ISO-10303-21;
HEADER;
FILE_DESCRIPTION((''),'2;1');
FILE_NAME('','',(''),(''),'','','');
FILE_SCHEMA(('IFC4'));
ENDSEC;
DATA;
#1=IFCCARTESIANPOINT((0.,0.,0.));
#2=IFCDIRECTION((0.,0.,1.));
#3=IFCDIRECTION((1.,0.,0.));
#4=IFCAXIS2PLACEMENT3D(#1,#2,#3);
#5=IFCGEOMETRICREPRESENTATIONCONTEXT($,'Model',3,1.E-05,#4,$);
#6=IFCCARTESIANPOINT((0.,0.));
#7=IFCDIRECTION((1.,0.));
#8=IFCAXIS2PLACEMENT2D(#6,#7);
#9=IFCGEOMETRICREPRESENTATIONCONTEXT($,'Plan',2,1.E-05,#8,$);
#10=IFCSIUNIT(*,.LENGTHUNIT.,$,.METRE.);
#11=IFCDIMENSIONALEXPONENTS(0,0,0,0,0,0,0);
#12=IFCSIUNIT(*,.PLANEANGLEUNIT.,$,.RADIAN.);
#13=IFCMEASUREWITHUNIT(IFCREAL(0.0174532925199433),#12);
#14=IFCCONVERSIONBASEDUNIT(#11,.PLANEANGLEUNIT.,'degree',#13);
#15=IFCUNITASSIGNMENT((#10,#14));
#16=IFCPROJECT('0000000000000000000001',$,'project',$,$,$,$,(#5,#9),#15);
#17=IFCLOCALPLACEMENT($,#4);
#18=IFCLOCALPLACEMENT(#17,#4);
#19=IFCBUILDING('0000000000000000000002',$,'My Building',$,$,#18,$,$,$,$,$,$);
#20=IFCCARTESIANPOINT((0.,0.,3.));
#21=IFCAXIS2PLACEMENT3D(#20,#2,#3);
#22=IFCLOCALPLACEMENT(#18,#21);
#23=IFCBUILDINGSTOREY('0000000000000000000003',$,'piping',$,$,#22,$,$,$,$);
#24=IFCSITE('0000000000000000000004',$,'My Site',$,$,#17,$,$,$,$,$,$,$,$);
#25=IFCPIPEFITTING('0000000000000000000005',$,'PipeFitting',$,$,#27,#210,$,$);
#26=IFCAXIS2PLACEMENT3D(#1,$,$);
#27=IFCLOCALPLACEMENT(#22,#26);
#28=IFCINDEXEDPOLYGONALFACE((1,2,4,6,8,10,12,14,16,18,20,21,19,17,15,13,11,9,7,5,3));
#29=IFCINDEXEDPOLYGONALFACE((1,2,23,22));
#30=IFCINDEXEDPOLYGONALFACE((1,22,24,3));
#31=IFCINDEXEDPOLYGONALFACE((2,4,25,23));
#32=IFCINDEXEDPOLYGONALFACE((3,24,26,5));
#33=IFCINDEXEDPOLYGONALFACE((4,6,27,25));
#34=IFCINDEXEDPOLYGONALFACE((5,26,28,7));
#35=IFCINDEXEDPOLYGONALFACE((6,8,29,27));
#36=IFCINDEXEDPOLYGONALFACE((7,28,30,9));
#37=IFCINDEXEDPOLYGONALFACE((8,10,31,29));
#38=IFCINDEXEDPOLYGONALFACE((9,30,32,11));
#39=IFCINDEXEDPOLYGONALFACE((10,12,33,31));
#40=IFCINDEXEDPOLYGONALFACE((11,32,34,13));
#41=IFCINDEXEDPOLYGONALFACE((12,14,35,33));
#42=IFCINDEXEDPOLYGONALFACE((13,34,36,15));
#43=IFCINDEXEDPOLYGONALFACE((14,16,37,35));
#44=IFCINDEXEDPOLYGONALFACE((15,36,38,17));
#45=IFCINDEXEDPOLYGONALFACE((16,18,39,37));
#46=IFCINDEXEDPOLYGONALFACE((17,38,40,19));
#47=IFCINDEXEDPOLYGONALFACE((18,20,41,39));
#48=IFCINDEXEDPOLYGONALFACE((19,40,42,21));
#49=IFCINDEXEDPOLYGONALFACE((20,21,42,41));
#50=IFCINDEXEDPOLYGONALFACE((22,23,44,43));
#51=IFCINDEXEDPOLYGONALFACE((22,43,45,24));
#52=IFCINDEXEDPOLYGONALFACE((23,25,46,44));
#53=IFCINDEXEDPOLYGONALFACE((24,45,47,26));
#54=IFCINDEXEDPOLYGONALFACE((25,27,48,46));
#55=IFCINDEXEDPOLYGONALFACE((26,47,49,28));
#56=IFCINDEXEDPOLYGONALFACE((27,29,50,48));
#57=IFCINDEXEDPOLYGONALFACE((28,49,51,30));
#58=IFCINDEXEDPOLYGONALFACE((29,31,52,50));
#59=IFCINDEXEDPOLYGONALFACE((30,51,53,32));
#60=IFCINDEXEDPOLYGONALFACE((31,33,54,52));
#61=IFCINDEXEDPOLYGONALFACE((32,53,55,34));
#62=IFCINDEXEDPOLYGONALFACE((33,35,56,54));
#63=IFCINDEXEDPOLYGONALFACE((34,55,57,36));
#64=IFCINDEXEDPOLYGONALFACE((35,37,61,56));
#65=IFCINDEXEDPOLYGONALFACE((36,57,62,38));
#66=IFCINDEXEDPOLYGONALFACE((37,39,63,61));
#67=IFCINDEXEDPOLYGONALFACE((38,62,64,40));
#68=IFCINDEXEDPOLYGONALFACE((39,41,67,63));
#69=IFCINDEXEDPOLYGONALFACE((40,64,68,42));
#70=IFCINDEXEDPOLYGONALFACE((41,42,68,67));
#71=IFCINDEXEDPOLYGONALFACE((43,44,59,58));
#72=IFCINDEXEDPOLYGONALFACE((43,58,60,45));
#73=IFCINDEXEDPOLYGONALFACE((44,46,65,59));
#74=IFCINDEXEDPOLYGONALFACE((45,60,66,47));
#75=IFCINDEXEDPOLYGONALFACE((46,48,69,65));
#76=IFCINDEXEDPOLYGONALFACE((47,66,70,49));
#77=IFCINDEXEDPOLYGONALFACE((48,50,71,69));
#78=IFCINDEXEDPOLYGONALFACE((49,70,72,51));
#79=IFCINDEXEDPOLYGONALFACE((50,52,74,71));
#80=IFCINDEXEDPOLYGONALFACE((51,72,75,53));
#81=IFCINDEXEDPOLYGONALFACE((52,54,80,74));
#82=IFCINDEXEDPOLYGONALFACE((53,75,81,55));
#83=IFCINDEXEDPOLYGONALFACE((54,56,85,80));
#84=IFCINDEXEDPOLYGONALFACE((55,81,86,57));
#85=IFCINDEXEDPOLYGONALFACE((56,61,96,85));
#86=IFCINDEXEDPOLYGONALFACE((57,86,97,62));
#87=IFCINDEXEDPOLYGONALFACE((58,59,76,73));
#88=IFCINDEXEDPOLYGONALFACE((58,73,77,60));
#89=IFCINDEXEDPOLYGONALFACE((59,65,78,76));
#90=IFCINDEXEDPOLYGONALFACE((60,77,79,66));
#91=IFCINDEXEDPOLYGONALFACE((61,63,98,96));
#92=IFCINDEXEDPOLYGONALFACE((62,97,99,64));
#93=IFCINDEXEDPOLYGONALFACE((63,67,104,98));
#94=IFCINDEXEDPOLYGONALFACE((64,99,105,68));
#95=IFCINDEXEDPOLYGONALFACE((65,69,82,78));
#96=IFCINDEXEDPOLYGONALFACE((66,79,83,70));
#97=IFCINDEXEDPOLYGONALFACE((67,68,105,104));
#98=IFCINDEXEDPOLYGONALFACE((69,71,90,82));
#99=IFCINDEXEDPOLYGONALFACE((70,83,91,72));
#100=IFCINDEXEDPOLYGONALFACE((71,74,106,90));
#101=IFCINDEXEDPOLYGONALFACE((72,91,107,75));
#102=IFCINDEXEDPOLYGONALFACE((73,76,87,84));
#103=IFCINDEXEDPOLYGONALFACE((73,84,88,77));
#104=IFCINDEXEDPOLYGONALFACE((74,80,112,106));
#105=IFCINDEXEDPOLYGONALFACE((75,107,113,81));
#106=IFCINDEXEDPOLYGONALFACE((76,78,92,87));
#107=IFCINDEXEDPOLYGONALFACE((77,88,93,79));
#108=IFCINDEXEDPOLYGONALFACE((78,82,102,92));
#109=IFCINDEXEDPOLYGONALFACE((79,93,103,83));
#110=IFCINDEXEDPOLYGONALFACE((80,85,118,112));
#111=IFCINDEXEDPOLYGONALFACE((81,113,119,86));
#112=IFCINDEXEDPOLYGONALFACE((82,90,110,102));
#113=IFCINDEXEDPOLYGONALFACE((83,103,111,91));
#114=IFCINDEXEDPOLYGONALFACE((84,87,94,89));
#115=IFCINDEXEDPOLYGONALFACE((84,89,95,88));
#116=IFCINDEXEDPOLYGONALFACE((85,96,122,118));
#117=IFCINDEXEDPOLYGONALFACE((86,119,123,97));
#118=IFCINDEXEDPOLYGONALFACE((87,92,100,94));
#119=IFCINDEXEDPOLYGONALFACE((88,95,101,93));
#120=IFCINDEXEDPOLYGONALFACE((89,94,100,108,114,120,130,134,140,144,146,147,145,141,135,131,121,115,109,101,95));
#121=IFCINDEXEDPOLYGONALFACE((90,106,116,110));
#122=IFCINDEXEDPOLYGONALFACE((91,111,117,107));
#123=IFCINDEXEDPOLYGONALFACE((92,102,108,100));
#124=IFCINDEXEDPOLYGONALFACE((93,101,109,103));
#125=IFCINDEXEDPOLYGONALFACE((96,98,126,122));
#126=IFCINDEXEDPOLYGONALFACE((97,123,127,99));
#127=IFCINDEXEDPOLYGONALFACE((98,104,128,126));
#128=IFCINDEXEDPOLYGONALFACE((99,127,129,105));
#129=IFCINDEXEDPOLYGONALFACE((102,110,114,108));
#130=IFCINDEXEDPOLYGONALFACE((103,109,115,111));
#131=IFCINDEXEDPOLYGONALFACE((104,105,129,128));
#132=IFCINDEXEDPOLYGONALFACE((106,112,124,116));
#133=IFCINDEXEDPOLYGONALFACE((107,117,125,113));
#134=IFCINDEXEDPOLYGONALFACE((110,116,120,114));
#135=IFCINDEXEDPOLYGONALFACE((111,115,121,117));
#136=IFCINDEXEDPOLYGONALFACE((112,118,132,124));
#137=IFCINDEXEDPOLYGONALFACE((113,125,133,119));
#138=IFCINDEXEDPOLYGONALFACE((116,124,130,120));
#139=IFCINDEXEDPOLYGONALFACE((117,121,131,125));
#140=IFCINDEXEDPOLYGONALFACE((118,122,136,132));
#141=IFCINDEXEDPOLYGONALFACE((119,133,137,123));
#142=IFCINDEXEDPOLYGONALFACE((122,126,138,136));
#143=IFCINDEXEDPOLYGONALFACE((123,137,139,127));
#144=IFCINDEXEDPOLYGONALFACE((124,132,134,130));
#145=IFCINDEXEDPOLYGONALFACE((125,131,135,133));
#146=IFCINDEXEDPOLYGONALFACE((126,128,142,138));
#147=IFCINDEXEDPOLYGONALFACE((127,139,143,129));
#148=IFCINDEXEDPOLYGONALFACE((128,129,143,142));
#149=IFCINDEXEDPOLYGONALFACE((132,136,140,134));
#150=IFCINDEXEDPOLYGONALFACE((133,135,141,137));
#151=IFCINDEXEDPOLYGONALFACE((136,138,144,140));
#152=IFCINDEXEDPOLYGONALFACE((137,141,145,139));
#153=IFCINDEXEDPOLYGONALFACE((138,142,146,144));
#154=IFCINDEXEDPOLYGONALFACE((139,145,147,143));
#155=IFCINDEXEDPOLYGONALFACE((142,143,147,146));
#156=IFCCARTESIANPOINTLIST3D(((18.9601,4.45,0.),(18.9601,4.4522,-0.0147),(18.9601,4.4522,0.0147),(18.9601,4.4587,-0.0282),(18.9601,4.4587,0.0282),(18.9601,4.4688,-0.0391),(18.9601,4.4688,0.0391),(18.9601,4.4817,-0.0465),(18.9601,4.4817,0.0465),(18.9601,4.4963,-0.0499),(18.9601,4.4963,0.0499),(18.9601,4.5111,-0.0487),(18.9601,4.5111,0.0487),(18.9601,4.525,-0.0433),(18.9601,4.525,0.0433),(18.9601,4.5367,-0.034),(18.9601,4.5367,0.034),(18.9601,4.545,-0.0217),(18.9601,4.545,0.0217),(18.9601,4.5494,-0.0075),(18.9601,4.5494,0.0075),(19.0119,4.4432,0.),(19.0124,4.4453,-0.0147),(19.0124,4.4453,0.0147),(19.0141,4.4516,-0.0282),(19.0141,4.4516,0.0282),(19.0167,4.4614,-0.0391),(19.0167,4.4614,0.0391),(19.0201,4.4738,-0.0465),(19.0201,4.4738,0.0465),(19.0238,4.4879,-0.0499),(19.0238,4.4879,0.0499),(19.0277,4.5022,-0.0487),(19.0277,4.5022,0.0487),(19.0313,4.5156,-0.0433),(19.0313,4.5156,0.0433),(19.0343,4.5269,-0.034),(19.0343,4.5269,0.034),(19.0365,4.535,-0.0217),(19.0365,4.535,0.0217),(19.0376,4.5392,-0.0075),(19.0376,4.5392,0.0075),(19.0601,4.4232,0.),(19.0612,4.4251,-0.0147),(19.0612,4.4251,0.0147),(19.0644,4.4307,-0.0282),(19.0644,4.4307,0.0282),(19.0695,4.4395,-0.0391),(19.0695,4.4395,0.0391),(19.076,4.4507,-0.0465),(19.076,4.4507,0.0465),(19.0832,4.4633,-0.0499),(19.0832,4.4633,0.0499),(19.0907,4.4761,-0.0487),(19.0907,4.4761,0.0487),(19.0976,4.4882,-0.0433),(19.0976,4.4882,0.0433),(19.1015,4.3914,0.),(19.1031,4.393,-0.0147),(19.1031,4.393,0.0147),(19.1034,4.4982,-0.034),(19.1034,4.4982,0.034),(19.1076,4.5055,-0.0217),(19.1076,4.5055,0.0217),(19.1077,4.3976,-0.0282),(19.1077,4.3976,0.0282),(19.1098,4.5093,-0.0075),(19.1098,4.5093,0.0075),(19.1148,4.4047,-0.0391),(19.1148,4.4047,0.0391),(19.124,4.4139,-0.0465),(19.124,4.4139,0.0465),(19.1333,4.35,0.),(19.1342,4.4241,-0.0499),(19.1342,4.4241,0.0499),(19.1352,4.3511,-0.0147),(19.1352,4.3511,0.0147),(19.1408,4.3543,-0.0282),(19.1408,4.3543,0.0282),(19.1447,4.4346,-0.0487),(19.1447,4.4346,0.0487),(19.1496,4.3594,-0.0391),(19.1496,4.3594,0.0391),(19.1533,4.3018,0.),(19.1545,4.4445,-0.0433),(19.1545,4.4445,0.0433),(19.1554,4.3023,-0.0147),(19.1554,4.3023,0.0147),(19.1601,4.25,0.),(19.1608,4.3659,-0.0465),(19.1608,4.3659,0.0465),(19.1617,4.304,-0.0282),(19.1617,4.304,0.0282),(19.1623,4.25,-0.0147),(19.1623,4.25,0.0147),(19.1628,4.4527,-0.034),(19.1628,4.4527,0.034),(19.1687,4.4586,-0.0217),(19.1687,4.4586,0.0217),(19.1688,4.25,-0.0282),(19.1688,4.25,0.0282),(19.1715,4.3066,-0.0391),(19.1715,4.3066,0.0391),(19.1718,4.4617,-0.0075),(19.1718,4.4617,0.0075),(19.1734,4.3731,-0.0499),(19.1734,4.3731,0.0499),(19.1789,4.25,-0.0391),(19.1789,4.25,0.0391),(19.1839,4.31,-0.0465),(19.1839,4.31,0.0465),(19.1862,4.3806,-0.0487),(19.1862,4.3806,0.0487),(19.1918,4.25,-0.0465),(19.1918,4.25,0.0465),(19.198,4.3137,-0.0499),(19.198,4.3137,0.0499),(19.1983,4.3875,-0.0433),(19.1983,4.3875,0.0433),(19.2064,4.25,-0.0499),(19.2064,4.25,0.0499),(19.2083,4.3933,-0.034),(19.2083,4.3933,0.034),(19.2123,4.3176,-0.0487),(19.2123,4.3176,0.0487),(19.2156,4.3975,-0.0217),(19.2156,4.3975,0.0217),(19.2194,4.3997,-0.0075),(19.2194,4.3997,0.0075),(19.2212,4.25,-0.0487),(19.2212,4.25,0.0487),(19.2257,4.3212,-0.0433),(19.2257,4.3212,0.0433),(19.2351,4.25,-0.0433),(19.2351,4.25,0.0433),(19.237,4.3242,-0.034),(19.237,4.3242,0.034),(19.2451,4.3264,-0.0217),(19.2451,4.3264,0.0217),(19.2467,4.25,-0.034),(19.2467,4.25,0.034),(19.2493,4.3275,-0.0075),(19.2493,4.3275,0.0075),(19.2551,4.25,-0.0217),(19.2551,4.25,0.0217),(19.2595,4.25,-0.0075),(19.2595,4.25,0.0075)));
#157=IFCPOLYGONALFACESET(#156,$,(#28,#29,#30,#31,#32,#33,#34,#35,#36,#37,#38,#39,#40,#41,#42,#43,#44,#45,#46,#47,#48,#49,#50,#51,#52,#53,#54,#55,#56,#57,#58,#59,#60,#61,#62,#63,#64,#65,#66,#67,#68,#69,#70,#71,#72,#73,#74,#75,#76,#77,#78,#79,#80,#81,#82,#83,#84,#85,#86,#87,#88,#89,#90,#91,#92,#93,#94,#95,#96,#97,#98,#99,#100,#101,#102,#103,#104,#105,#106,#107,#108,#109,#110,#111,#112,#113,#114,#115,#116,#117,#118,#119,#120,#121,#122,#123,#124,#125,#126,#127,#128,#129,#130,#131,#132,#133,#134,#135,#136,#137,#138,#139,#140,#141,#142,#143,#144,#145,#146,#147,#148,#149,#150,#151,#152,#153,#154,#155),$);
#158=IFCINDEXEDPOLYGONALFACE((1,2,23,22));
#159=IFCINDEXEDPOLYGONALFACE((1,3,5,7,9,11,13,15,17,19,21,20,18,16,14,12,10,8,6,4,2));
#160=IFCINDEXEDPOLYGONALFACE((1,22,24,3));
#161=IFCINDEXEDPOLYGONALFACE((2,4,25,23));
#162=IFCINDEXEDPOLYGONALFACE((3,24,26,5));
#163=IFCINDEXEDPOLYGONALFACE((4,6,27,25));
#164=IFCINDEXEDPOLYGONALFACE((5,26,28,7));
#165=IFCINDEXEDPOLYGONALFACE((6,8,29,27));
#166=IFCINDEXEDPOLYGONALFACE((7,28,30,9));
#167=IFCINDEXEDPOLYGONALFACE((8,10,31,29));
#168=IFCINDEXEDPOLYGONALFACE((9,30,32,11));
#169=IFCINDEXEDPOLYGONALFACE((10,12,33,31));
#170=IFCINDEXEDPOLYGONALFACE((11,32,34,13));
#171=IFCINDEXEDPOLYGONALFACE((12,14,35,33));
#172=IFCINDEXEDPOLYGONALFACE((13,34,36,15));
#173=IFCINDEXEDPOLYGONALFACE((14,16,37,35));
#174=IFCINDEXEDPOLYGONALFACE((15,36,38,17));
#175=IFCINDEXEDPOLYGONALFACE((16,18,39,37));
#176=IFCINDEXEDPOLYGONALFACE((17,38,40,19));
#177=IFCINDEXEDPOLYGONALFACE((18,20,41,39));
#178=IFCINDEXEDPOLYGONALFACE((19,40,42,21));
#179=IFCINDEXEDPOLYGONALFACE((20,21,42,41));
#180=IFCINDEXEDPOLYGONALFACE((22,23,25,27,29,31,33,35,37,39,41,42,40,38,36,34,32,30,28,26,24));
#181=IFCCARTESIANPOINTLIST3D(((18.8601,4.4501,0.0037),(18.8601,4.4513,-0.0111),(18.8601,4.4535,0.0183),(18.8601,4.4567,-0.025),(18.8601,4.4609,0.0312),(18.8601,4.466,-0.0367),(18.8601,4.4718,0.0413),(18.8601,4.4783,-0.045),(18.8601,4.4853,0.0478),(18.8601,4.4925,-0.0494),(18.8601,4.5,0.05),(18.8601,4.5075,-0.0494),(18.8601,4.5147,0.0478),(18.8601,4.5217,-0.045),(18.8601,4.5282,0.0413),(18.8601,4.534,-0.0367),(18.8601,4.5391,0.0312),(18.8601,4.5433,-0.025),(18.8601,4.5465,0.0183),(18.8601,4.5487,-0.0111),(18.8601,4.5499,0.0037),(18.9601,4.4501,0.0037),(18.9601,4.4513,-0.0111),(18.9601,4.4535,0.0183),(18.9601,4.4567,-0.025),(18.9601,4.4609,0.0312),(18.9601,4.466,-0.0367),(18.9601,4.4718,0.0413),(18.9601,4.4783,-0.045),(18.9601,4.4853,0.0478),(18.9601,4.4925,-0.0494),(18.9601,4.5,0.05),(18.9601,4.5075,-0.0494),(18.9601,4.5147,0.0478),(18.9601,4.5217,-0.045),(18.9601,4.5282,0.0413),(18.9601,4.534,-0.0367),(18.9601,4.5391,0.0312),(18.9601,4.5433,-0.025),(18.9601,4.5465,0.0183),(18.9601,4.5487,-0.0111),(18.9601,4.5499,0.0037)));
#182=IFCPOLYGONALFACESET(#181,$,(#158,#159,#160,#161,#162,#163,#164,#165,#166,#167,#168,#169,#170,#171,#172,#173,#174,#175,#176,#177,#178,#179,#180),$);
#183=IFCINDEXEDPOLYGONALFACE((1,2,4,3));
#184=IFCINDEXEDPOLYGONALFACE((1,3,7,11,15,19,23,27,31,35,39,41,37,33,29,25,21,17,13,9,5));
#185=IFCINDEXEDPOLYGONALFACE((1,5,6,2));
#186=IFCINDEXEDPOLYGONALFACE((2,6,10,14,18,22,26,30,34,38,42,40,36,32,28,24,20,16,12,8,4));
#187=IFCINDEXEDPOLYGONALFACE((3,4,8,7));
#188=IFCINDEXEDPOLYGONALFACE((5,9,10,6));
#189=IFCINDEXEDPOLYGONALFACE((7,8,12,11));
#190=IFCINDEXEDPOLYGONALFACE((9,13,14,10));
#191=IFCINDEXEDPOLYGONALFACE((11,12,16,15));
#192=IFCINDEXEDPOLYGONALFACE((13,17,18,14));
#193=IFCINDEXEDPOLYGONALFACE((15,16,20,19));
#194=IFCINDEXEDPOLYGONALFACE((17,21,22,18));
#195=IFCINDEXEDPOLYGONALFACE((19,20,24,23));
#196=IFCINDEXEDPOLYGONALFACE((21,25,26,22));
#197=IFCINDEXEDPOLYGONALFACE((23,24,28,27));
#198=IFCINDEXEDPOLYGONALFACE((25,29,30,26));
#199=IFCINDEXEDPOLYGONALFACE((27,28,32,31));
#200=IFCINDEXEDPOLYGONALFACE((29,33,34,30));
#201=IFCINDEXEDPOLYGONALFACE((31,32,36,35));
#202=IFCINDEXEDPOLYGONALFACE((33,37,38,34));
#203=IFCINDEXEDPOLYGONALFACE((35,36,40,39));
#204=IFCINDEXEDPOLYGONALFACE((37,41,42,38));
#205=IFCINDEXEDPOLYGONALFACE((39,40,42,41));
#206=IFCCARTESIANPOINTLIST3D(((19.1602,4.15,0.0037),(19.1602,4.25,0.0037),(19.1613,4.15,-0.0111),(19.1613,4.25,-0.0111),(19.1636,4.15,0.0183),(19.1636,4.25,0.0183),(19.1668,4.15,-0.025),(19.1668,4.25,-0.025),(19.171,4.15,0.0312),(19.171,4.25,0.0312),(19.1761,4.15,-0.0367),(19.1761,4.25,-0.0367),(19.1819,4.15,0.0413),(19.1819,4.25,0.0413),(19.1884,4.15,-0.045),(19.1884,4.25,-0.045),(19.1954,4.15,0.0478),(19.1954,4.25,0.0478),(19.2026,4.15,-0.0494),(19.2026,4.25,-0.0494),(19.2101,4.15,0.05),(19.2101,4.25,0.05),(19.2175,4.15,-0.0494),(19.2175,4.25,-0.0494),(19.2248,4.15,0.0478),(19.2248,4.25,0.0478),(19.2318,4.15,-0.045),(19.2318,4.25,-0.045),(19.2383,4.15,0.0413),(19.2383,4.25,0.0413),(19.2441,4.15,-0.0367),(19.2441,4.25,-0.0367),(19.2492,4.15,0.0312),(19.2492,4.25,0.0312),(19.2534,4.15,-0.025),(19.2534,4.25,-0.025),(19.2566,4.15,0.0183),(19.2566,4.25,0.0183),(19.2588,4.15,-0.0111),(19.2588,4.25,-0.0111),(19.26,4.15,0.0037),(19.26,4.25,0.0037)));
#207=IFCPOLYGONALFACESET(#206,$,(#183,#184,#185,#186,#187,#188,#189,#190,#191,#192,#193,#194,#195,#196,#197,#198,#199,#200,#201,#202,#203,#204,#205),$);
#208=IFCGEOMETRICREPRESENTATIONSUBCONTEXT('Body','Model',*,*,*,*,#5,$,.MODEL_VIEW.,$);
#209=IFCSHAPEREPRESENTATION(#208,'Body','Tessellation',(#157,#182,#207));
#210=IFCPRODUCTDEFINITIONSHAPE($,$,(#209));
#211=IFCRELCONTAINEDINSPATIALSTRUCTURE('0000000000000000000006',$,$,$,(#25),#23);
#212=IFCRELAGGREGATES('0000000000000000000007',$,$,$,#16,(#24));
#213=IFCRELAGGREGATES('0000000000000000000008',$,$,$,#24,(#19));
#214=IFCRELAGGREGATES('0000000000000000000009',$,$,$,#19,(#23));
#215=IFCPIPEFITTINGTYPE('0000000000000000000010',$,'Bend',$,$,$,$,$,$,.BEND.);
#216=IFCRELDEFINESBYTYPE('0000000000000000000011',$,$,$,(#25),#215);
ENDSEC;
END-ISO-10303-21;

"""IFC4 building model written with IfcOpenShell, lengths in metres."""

from ifc_helpers import new_model, entity, si_unit, converted_unit, frame, origin_with_axes, origin_2d_with_axis, place, context, subcontext, project, spatial, circle, extrude, source, transform, mapped, type_object, type_shapes, element, save


model = new_model("IFC4")

# Units and contexts
model_context = context("Model", 3, precision=1e-05, world=origin_with_axes())
plan_context = context("Plan", 2, precision=1e-05, world=origin_2d_with_axis())
body_context = subcontext(model_context, "Body", "Model", "MODEL_VIEW")
ifc_project = project(units=[si_unit("LENGTHUNIT", "METRE"), converted_unit("PLANEANGLEUNIT", "degree", entity("IfcReal", 0.0174532925199433), si_unit("PLANEANGLEUNIT", "RADIAN"), dimensions=[0, 0, 0, 0, 0, 0, 0])], contexts=[model_context, plan_context])

# Site, building, storey
site_placement = place(None, origin_with_axes())
site = spatial("IfcSite", under=ifc_project, at=site_placement, Name="My Site")
building_placement = place(site_placement, origin_with_axes())
building = spatial("IfcBuilding", under=site, at=building_placement, Name="My Building")
storey_placement = place(building_placement, frame((0.0, 0.0, 3.0), z_axis=(0.0, 0.0, 1.0), x_axis=(1.0, 0.0, 0.0)))
storey = spatial("IfcBuildingStorey", under=building, at=storey_placement, Name="piping")

# Pipe fitting
pipe_fitting_type = type_object("IfcPipeFittingType", Name="Bend", PredefinedType="BEND")
shared_shape = source(origin_with_axes(), body_context, "Body", "SolidModel", [
    entity("IfcSweptDiskSolid", entity("IfcIndexedPolyCurve", entity("IfcCartesianPointList3D", [[0.0, 0.0, -0.1], [0.0, -0.0732, -0.2768], [0.0, -0.25, -0.35]]), [entity("IfcArcIndex", [1, 2, 3])]), 0.05),
    extrude(circle(Radius=0.05), origin_with_axes(), (0.0, 0.0, -1.0), 0.1),
    extrude(circle(Radius=0.05), frame((0.0, -0.25, -0.35), z_axis=(0.0, -1.0, 0.0), x_axis=(1.0, 0.0, 0.0)), (0.0, 0.0, 1.0), 0.1),
])
type_shapes(pipe_fitting_type, [shared_shape])
for number, where, z_axis, x_axis, name in (
    (1, (18.8601, 4.5, 0.0), (-1.0, 0.0, 0.0), (0.0, 0.0, 1.0), "PipeFitting"),
):
    element("IfcPipeFitting", number, at=place(storey_placement, frame(where, z_axis=z_axis, x_axis=x_axis)), inside=storey, type_object=pipe_fitting_type, Name=name, context=body_context, shape_type="MappedRepresentation", body=[
        mapped(shared_shape, transform((0.0, 0.0, 0.0), x_axis=(1.0, 0.0, 0.0), y_axis=(0.0, 1.0, 0.0), z_axis=(0.0, 0.0, 1.0), scale=1.0)),
    ])

save(model, "model.ifc")
